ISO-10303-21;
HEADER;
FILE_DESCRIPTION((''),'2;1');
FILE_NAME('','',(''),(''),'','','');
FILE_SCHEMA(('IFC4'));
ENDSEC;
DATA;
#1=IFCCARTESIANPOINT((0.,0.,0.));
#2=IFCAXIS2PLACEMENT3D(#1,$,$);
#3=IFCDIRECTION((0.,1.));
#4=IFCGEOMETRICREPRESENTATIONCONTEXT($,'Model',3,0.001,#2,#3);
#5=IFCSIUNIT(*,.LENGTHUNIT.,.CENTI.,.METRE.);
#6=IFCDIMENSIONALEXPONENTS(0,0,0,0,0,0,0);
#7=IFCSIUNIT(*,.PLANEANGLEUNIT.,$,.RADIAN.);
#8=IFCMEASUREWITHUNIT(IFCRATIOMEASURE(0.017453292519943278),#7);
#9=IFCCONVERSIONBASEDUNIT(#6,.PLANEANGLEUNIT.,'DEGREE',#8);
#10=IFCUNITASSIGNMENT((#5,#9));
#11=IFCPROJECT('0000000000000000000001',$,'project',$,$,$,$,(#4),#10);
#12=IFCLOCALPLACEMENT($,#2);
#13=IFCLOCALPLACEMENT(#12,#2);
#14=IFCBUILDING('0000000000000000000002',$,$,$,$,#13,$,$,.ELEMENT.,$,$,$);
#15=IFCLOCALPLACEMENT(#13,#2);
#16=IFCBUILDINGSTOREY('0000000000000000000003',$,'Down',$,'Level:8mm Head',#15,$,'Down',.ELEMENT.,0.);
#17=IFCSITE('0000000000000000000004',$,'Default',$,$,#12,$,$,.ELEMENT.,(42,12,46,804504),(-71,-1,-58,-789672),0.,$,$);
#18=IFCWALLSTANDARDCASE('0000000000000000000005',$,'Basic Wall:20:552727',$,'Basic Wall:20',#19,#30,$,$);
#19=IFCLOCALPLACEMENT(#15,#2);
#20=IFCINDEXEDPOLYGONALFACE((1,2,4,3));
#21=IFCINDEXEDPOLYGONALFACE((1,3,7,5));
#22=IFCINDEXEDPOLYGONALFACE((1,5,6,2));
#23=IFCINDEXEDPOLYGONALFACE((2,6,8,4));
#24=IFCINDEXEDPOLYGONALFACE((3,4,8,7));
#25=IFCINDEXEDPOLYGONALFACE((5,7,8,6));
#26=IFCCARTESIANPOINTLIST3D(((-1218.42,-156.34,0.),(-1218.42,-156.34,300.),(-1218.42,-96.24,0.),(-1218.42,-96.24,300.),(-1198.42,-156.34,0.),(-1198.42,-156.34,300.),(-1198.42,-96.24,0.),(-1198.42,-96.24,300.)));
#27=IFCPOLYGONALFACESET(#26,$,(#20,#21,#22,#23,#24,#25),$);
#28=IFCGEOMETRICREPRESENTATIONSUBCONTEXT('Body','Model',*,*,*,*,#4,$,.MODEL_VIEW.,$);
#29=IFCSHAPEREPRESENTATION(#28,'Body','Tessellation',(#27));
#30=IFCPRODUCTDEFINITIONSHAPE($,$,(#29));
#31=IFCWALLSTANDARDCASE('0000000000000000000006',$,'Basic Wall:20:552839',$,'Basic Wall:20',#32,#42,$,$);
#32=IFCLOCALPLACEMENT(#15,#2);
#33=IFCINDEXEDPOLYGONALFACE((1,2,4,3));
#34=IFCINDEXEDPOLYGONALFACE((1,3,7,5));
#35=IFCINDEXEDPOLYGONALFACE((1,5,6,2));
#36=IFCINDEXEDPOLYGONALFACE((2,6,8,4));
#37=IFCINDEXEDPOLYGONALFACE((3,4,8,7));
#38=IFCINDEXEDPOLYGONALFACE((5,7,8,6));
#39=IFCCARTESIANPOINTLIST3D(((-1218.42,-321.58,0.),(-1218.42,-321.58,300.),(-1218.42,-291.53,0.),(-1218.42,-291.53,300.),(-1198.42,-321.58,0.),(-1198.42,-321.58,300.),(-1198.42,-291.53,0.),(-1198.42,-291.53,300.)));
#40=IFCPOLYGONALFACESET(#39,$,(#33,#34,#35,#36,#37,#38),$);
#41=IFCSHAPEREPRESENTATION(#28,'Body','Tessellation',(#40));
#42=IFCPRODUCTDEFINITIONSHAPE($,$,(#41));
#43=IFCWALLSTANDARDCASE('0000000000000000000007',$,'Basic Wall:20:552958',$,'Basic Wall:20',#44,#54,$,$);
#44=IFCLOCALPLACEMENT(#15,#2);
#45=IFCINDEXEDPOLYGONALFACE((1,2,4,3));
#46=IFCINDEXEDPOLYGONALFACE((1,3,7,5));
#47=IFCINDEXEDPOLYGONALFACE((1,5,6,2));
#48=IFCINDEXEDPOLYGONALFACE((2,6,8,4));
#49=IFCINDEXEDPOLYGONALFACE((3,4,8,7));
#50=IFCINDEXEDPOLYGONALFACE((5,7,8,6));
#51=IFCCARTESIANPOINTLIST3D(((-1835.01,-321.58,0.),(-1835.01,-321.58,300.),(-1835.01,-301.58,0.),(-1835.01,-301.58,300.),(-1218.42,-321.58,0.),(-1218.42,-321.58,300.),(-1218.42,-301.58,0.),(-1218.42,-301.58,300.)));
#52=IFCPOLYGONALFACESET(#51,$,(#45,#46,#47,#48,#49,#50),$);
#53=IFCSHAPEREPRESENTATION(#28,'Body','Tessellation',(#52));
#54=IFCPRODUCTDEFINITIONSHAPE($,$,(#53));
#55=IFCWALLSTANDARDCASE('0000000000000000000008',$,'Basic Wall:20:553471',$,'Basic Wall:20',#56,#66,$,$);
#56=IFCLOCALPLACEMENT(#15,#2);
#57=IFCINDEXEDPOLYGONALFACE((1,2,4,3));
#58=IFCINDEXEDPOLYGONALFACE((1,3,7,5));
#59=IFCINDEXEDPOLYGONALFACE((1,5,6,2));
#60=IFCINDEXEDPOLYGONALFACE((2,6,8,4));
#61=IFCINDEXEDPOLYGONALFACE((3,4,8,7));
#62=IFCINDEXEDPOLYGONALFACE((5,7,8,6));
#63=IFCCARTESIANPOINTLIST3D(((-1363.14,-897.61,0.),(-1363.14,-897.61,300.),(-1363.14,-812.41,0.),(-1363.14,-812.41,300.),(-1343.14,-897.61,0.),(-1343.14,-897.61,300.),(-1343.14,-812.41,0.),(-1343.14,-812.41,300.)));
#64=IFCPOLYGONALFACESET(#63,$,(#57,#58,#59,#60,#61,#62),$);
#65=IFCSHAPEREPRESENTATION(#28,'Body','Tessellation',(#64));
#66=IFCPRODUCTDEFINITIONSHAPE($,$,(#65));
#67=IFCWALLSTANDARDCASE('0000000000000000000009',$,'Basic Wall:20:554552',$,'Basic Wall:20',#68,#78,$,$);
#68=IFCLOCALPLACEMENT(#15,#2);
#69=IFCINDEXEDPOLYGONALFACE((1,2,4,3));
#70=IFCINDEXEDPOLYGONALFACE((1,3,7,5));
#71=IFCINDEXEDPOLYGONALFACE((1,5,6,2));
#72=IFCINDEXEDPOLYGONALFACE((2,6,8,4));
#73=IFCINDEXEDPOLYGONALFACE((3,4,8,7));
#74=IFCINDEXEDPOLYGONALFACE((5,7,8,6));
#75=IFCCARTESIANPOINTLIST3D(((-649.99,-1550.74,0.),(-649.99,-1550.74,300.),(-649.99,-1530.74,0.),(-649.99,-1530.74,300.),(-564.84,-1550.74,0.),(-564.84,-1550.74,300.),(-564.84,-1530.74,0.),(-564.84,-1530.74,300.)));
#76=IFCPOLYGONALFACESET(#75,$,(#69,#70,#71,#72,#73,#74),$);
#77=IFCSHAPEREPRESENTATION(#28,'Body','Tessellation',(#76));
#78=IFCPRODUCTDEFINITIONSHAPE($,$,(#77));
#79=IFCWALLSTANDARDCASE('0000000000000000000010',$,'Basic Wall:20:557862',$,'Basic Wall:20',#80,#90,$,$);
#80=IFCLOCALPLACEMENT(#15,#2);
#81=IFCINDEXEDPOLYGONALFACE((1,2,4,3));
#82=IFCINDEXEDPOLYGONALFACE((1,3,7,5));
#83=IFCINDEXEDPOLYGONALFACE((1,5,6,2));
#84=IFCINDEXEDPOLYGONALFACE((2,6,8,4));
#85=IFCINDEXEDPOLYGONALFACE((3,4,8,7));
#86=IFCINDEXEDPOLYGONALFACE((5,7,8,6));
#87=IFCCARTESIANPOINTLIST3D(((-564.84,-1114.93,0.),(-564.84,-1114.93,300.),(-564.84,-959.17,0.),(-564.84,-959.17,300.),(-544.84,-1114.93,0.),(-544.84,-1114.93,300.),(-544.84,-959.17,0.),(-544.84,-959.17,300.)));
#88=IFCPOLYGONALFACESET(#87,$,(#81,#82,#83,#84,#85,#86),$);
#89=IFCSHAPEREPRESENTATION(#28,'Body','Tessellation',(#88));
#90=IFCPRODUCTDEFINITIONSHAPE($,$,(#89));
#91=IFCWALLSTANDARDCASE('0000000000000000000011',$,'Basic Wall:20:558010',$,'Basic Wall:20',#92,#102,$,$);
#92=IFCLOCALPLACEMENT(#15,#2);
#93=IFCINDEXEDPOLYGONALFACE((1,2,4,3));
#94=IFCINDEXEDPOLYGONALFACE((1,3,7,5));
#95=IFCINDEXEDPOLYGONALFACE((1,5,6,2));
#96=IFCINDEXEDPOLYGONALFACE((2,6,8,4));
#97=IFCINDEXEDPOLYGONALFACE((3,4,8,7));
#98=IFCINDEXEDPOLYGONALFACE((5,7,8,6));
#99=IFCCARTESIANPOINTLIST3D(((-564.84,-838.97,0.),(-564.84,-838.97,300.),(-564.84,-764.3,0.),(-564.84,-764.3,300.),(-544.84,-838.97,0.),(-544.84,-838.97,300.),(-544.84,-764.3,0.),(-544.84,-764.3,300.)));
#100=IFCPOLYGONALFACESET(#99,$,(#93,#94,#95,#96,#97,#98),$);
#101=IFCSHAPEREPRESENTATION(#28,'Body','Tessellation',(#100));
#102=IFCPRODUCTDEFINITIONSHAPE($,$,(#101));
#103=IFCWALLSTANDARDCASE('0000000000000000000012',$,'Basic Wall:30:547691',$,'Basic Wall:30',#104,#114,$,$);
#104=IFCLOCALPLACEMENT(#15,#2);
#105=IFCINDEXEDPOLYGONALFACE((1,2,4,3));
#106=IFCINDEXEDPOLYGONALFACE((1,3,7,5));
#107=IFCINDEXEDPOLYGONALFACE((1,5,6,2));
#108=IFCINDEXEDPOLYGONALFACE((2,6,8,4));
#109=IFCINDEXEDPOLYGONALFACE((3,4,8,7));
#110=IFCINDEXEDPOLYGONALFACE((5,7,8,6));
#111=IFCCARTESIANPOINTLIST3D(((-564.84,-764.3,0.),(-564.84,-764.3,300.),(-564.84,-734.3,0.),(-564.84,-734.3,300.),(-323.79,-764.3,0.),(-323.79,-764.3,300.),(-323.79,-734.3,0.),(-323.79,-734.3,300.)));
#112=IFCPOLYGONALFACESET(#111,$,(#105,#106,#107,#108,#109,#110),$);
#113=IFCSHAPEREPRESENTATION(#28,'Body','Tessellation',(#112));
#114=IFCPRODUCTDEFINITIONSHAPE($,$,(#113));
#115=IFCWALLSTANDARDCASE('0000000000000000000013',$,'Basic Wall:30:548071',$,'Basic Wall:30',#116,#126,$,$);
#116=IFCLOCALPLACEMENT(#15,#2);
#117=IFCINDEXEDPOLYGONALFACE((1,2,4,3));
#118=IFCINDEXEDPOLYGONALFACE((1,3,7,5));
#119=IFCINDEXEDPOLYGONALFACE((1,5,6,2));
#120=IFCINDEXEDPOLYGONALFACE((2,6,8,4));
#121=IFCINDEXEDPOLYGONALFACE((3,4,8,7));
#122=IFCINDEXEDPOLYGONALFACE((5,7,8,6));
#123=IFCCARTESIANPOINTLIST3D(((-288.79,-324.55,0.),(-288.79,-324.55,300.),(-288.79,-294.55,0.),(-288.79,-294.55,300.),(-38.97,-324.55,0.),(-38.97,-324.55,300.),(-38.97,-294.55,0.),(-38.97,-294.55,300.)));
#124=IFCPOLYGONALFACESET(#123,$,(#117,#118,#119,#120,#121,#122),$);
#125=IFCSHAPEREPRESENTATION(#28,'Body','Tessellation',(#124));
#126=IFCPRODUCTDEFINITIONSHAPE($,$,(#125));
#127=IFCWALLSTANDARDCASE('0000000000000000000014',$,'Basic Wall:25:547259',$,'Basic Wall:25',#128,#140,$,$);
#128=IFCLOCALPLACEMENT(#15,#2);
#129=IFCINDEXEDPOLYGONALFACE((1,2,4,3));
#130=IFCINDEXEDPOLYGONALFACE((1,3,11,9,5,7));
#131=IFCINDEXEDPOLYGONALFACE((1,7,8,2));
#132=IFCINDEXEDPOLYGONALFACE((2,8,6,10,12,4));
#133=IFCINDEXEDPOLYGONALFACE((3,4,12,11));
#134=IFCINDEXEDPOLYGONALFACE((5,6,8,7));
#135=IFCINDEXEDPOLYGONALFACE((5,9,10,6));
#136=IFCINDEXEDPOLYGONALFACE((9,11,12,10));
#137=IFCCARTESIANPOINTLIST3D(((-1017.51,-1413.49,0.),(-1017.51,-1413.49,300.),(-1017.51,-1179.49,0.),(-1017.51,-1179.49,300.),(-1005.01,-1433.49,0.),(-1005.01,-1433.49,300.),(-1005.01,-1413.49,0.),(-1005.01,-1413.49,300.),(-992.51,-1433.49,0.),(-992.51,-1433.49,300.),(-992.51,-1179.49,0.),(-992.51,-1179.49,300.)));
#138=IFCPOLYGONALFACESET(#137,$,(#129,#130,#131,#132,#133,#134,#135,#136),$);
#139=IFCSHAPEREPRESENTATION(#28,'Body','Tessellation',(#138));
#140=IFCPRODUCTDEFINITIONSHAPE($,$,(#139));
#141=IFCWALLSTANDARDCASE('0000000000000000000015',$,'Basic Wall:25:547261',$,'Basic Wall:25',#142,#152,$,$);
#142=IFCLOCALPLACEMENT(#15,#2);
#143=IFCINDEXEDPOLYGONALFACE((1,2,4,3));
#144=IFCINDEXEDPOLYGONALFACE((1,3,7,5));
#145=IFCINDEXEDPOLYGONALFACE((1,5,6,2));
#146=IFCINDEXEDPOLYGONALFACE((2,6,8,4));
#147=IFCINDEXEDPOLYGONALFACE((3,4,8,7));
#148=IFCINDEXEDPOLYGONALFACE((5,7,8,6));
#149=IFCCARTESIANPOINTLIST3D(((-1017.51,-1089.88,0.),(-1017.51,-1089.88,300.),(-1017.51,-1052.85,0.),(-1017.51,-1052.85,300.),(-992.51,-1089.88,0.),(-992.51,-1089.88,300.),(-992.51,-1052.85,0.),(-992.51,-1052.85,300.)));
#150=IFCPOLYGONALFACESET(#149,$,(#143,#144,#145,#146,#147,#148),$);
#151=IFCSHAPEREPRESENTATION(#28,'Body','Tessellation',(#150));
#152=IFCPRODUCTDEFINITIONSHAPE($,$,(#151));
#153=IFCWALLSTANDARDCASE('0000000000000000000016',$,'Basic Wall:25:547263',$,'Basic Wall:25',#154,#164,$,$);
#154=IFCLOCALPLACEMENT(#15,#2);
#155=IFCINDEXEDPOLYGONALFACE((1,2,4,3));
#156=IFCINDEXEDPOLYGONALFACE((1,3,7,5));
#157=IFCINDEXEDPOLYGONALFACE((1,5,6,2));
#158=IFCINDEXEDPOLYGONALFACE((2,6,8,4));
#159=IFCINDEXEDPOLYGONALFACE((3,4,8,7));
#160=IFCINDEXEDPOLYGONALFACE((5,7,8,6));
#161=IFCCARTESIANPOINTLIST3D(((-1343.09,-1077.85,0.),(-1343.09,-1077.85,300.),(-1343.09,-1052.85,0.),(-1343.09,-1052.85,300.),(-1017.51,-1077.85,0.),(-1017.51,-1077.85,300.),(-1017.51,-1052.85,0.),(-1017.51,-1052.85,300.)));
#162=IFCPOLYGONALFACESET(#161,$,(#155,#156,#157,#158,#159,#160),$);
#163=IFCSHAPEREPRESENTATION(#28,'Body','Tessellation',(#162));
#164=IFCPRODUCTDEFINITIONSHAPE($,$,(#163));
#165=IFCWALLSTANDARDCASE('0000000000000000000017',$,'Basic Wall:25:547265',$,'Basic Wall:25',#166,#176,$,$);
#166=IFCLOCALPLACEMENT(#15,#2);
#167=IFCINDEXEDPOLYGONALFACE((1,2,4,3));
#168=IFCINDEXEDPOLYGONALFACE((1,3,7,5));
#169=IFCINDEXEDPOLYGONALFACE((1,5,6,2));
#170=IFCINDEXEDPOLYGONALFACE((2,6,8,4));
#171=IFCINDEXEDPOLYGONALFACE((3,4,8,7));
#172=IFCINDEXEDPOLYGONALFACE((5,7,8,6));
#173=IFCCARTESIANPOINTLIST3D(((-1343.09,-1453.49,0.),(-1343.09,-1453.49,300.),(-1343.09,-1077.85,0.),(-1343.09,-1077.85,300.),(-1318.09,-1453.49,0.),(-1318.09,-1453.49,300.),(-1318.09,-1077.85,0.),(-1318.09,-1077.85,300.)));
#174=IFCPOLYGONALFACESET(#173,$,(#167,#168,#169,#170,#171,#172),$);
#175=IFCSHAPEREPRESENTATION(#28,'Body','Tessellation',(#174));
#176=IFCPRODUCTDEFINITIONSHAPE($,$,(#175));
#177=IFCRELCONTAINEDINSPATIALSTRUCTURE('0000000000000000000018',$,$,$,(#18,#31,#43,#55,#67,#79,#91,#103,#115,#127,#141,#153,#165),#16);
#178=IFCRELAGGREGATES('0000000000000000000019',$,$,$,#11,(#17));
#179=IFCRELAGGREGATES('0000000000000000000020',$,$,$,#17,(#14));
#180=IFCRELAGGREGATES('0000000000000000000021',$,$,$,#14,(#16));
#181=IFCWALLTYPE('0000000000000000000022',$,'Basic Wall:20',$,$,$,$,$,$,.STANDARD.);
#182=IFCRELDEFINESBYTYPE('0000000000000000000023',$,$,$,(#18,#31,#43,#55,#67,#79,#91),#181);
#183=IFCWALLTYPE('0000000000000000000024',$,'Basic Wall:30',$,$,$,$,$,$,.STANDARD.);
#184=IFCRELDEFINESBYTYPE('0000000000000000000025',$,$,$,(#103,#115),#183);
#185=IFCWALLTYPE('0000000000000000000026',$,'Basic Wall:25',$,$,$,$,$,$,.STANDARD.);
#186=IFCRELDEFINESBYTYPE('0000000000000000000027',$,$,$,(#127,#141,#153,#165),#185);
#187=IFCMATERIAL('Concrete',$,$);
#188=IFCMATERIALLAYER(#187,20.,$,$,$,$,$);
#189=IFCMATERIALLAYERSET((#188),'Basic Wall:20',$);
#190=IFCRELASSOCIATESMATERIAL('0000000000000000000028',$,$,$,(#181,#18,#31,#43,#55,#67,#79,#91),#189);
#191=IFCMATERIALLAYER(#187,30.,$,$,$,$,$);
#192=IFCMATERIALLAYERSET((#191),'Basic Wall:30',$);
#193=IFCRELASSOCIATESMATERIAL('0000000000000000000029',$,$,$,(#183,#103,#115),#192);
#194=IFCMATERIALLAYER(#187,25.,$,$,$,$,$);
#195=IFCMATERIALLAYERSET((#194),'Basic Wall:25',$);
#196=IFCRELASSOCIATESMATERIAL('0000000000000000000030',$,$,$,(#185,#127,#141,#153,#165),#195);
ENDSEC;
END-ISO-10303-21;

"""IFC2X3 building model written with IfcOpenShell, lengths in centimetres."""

from ifc_helpers import new_model, entity, si_unit, converted_unit, direction, frame, frame_2d, origin, place, context, subcontext, project, spatial, polyline, rectangle, outline, extrude, material, layer, layer_set, layer_usage, type_object, element, save


model = new_model("IFC2X3")

# Units and contexts
model_context = context("Model", 3, precision=0.001, world=origin(), true_north=direction((0.0, 1.0)))
body_context = subcontext(model_context, "Body", "Model", "MODEL_VIEW")
ifc_project = project(units=[si_unit("LENGTHUNIT", "METRE", prefix="CENTI"), converted_unit("PLANEANGLEUNIT", "DEGREE", entity("IfcRatioMeasure", 0.017453292519943278), si_unit("PLANEANGLEUNIT", "RADIAN"), dimensions=[0, 0, 0, 0, 0, 0, 0])], contexts=[model_context])

# Site, building, storey
site_placement = place(None, origin())
site = spatial("IfcSite", under=ifc_project, at=site_placement, Name="Default", CompositionType="ELEMENT", RefLatitude=(42, 12, 46, 804504), RefLongitude=(-71, -1, -58, -789672), RefElevation=0.0)
building_placement = place(site_placement, origin())
building = spatial("IfcBuilding", under=site, at=building_placement, CompositionType="ELEMENT")
storey_placement = place(building_placement, origin())
storey = spatial("IfcBuildingStorey", under=building, at=storey_placement, Name="Down", ObjectType="Level:8mm Head", LongName="Down", CompositionType="ELEMENT", Elevation=0.0)

# Walls
ifc_material = material(Name="Concrete")
ifc_layer_1 = layer(ifc_material, 20.0)
ifc_layer_set_1 = layer_set([ifc_layer_1], Name="Basic Wall:20")
wall_type_1 = type_object("IfcWallType", Name="Basic Wall:20", PredefinedType="STANDARD", material=ifc_layer_set_1)
ifc_layer_usage_1 = layer_usage(ifc_layer_set_1, "AXIS2", "POSITIVE", -10.0)
wall_1_placement = place(storey_placement, frame((-1208.42, -156.34, 0.0), z_axis=(0.0, 0.0, 1.0), x_axis=(0.0, 1.0, 0.0)))
element("IfcWallStandardCase", 1, at=wall_1_placement, inside=storey, type_object=wall_type_1, material=ifc_layer_usage_1, Name="Basic Wall:20:552727", ObjectType="Basic Wall:20", context=body_context, shape_type="SweptSolid", body=[
    extrude(rectangle(XDim=60.1, YDim=20.0, at=frame_2d((30.05, 0.0), x_axis=(-1.0, 0.0))), origin(), (0.0, 0.0, 1.0), 300.0),
])
ifc_layer_usage_2 = layer_usage(ifc_layer_set_1, "AXIS2", "NEGATIVE", 10.0)
wall_2_placement = place(storey_placement, frame((-1208.42, -291.53, 0.0), z_axis=(0.0, 0.0, 1.0), x_axis=(0.0, -1.0, 0.0)))
element("IfcWallStandardCase", 2, at=wall_2_placement, inside=storey, type_object=wall_type_1, material=ifc_layer_usage_2, Name="Basic Wall:20:552839", ObjectType="Basic Wall:20", context=body_context, shape_type="SweptSolid", body=[
    extrude(rectangle(XDim=30.05, YDim=20.0, at=frame_2d((15.02, 0.0), x_axis=(-1.0, 0.0))), origin(), (0.0, 0.0, 1.0), 300.0),
])
ifc_layer_usage_3 = layer_usage(ifc_layer_set_1, "AXIS2", "NEGATIVE", 10.0)
wall_3_placement = place(storey_placement, frame((-1218.42, -311.58, 0.0), z_axis=(0.0, 0.0, 1.0), x_axis=(-1.0, 0.0, 0.0)))
element("IfcWallStandardCase", 3, at=wall_3_placement, inside=storey, type_object=wall_type_1, material=ifc_layer_usage_3, Name="Basic Wall:20:552958", ObjectType="Basic Wall:20", context=body_context, shape_type="SweptSolid", body=[
    extrude(rectangle(XDim=616.59, YDim=20.0, at=frame_2d((308.3, 0.0), x_axis=(-1.0, 0.0))), origin(), (0.0, 0.0, 1.0), 300.0),
])
ifc_layer_usage_4 = layer_usage(ifc_layer_set_1, "AXIS2", "POSITIVE", -10.0)
wall_4_placement = place(storey_placement, frame((-1353.14, -897.61, 0.0), z_axis=(0.0, 0.0, 1.0), x_axis=(0.0, 1.0, 0.0)))
element("IfcWallStandardCase", 4, at=wall_4_placement, inside=storey, type_object=wall_type_1, material=ifc_layer_usage_4, Name="Basic Wall:20:553471", ObjectType="Basic Wall:20", context=body_context, shape_type="SweptSolid", body=[
    extrude(rectangle(XDim=85.2, YDim=20.0, at=frame_2d((42.6, 0.0), x_axis=(-1.0, 0.0))), origin(), (0.0, 0.0, 1.0), 300.0),
])
ifc_layer_usage_5 = layer_usage(ifc_layer_set_1, "AXIS2", "POSITIVE", -10.0)
wall_5_placement = place(storey_placement, frame((-649.99, -1540.74, 0.0)))
element("IfcWallStandardCase", 5, at=wall_5_placement, inside=storey, type_object=wall_type_1, material=ifc_layer_usage_5, Name="Basic Wall:20:554552", ObjectType="Basic Wall:20", context=body_context, shape_type="SweptSolid", body=[
    extrude(rectangle(XDim=85.15, YDim=20.0, at=frame_2d((42.57, 0.0), x_axis=(-1.0, 0.0))), origin(), (0.0, 0.0, 1.0), 300.0),
])
ifc_layer_usage_6 = layer_usage(ifc_layer_set_1, "AXIS2", "NEGATIVE", 10.0)
wall_6_placement = place(storey_placement, frame((-554.84, -1114.93, 0.0), z_axis=(0.0, 0.0, 1.0), x_axis=(0.0, 1.0, 0.0)))
element("IfcWallStandardCase", 6, at=wall_6_placement, inside=storey, type_object=wall_type_1, material=ifc_layer_usage_6, Name="Basic Wall:20:557862", ObjectType="Basic Wall:20", context=body_context, shape_type="SweptSolid", body=[
    extrude(rectangle(XDim=155.76, YDim=20.0, at=frame_2d((77.88, 0.0), x_axis=(-1.0, 0.0))), origin(), (0.0, 0.0, 1.0), 300.0),
])
ifc_layer_usage_7 = layer_usage(ifc_layer_set_1, "AXIS2", "NEGATIVE", 10.0)
wall_7_placement = place(storey_placement, frame((-554.84, -838.97, 0.0), z_axis=(0.0, 0.0, 1.0), x_axis=(0.0, 1.0, 0.0)))
element("IfcWallStandardCase", 7, at=wall_7_placement, inside=storey, type_object=wall_type_1, material=ifc_layer_usage_7, Name="Basic Wall:20:558010", ObjectType="Basic Wall:20", context=body_context, shape_type="SweptSolid", body=[
    extrude(rectangle(XDim=74.67, YDim=20.0, at=frame_2d((37.34, 0.0), x_axis=(-1.0, 0.0))), origin(), (0.0, 0.0, 1.0), 300.0),
])
ifc_layer_2 = layer(ifc_material, 30.0)
ifc_layer_set_2 = layer_set([ifc_layer_2], Name="Basic Wall:30")
ifc_layer_usage_8 = layer_usage(ifc_layer_set_2, "AXIS2", "NEGATIVE", 15.0)
wall_type_2 = type_object("IfcWallType", Name="Basic Wall:30", PredefinedType="STANDARD", material=ifc_layer_set_2)
wall_8_placement = place(storey_placement, frame((-564.84, -749.3, 0.0)))
element("IfcWallStandardCase", 8, at=wall_8_placement, inside=storey, type_object=wall_type_2, material=ifc_layer_usage_8, Name="Basic Wall:30:547691", ObjectType="Basic Wall:30", context=body_context, shape_type="SweptSolid", body=[
    extrude(rectangle(XDim=241.05, YDim=30.0, at=frame_2d((120.52, 0.0), x_axis=(-1.0, 0.0))), origin(), (0.0, 0.0, 1.0), 300.0),
])
ifc_layer_usage_9 = layer_usage(ifc_layer_set_2, "AXIS2", "NEGATIVE", 15.0)
wall_9_placement = place(storey_placement, frame((-288.79, -309.55, 0.0)))
element("IfcWallStandardCase", 9, at=wall_9_placement, inside=storey, type_object=wall_type_2, material=ifc_layer_usage_9, Name="Basic Wall:30:548071", ObjectType="Basic Wall:30", context=body_context, shape_type="SweptSolid", body=[
    extrude(rectangle(XDim=249.83, YDim=30.0, at=frame_2d((124.91, 0.0), x_axis=(-1.0, 0.0))), origin(), (0.0, 0.0, 1.0), 300.0),
])
ifc_layer_3 = layer(ifc_material, 25.0)
ifc_layer_set_3 = layer_set([ifc_layer_3], Name="Basic Wall:25")
ifc_layer_usage_10 = layer_usage(ifc_layer_set_3, "AXIS2", "POSITIVE", -12.5)
wall_type_3 = type_object("IfcWallType", Name="Basic Wall:25", PredefinedType="STANDARD", material=ifc_layer_set_3)
wall_10_placement = place(storey_placement, frame((-1005.01, -1433.49, 0.0), z_axis=(0.0, 0.0, 1.0), x_axis=(0.0, 1.0, 0.0)))
element("IfcWallStandardCase", 10, at=wall_10_placement, inside=storey, type_object=wall_type_3, material=ifc_layer_usage_10, Name="Basic Wall:25:547259", ObjectType="Basic Wall:25", context=body_context, shape_type="SweptSolid", body=[
    extrude(outline(polyline([(254.0, -12.5), (254.0, 12.5), (20.0, 12.5), (20.0, 0.0), (0.0, 0.0), (0.0, -12.5), (254.0, -12.5)])), origin(), (0.0, 0.0, 1.0), 300.0),
])
ifc_layer_usage_11 = layer_usage(ifc_layer_set_3, "AXIS2", "POSITIVE", -12.5)
wall_11_placement = place(storey_placement, frame((-1005.01, -1089.88, 0.0), z_axis=(0.0, 0.0, 1.0), x_axis=(0.0, 1.0, 0.0)))
element("IfcWallStandardCase", 11, at=wall_11_placement, inside=storey, type_object=wall_type_3, material=ifc_layer_usage_11, Name="Basic Wall:25:547261", ObjectType="Basic Wall:25", context=body_context, shape_type="SweptSolid", body=[
    extrude(rectangle(XDim=37.03, YDim=25.0, at=frame_2d((18.51, 0.0), x_axis=(-1.0, 0.0))), origin(), (0.0, 0.0, 1.0), 300.0),
])
ifc_layer_usage_12 = layer_usage(ifc_layer_set_3, "AXIS2", "POSITIVE", -12.5)
wall_12_placement = place(storey_placement, frame((-1017.51, -1065.35, 0.0), z_axis=(0.0, 0.0, 1.0), x_axis=(-1.0, 0.0, 0.0)))
element("IfcWallStandardCase", 12, at=wall_12_placement, inside=storey, type_object=wall_type_3, material=ifc_layer_usage_12, Name="Basic Wall:25:547263", ObjectType="Basic Wall:25", context=body_context, shape_type="SweptSolid", body=[
    extrude(rectangle(XDim=325.59, YDim=25.0, at=frame_2d((162.79, 0.0), x_axis=(-1.0, 0.0))), origin(), (0.0, 0.0, 1.0), 300.0),
])
ifc_layer_usage_13 = layer_usage(ifc_layer_set_3, "AXIS2", "POSITIVE", -12.5)
wall_13_placement = place(storey_placement, frame((-1330.59, -1077.85, 0.0), z_axis=(0.0, 0.0, 1.0), x_axis=(0.0, -1.0, 0.0)))
element("IfcWallStandardCase", 13, at=wall_13_placement, inside=storey, type_object=wall_type_3, material=ifc_layer_usage_13, Name="Basic Wall:25:547265", ObjectType="Basic Wall:25", context=body_context, shape_type="SweptSolid", body=[
    extrude(rectangle(XDim=375.63, YDim=25.0, at=frame_2d((187.82, 0.0), x_axis=(-1.0, 0.0))), origin(), (0.0, 0.0, 1.0), 300.0),
])

save(model, "model.ifc")
